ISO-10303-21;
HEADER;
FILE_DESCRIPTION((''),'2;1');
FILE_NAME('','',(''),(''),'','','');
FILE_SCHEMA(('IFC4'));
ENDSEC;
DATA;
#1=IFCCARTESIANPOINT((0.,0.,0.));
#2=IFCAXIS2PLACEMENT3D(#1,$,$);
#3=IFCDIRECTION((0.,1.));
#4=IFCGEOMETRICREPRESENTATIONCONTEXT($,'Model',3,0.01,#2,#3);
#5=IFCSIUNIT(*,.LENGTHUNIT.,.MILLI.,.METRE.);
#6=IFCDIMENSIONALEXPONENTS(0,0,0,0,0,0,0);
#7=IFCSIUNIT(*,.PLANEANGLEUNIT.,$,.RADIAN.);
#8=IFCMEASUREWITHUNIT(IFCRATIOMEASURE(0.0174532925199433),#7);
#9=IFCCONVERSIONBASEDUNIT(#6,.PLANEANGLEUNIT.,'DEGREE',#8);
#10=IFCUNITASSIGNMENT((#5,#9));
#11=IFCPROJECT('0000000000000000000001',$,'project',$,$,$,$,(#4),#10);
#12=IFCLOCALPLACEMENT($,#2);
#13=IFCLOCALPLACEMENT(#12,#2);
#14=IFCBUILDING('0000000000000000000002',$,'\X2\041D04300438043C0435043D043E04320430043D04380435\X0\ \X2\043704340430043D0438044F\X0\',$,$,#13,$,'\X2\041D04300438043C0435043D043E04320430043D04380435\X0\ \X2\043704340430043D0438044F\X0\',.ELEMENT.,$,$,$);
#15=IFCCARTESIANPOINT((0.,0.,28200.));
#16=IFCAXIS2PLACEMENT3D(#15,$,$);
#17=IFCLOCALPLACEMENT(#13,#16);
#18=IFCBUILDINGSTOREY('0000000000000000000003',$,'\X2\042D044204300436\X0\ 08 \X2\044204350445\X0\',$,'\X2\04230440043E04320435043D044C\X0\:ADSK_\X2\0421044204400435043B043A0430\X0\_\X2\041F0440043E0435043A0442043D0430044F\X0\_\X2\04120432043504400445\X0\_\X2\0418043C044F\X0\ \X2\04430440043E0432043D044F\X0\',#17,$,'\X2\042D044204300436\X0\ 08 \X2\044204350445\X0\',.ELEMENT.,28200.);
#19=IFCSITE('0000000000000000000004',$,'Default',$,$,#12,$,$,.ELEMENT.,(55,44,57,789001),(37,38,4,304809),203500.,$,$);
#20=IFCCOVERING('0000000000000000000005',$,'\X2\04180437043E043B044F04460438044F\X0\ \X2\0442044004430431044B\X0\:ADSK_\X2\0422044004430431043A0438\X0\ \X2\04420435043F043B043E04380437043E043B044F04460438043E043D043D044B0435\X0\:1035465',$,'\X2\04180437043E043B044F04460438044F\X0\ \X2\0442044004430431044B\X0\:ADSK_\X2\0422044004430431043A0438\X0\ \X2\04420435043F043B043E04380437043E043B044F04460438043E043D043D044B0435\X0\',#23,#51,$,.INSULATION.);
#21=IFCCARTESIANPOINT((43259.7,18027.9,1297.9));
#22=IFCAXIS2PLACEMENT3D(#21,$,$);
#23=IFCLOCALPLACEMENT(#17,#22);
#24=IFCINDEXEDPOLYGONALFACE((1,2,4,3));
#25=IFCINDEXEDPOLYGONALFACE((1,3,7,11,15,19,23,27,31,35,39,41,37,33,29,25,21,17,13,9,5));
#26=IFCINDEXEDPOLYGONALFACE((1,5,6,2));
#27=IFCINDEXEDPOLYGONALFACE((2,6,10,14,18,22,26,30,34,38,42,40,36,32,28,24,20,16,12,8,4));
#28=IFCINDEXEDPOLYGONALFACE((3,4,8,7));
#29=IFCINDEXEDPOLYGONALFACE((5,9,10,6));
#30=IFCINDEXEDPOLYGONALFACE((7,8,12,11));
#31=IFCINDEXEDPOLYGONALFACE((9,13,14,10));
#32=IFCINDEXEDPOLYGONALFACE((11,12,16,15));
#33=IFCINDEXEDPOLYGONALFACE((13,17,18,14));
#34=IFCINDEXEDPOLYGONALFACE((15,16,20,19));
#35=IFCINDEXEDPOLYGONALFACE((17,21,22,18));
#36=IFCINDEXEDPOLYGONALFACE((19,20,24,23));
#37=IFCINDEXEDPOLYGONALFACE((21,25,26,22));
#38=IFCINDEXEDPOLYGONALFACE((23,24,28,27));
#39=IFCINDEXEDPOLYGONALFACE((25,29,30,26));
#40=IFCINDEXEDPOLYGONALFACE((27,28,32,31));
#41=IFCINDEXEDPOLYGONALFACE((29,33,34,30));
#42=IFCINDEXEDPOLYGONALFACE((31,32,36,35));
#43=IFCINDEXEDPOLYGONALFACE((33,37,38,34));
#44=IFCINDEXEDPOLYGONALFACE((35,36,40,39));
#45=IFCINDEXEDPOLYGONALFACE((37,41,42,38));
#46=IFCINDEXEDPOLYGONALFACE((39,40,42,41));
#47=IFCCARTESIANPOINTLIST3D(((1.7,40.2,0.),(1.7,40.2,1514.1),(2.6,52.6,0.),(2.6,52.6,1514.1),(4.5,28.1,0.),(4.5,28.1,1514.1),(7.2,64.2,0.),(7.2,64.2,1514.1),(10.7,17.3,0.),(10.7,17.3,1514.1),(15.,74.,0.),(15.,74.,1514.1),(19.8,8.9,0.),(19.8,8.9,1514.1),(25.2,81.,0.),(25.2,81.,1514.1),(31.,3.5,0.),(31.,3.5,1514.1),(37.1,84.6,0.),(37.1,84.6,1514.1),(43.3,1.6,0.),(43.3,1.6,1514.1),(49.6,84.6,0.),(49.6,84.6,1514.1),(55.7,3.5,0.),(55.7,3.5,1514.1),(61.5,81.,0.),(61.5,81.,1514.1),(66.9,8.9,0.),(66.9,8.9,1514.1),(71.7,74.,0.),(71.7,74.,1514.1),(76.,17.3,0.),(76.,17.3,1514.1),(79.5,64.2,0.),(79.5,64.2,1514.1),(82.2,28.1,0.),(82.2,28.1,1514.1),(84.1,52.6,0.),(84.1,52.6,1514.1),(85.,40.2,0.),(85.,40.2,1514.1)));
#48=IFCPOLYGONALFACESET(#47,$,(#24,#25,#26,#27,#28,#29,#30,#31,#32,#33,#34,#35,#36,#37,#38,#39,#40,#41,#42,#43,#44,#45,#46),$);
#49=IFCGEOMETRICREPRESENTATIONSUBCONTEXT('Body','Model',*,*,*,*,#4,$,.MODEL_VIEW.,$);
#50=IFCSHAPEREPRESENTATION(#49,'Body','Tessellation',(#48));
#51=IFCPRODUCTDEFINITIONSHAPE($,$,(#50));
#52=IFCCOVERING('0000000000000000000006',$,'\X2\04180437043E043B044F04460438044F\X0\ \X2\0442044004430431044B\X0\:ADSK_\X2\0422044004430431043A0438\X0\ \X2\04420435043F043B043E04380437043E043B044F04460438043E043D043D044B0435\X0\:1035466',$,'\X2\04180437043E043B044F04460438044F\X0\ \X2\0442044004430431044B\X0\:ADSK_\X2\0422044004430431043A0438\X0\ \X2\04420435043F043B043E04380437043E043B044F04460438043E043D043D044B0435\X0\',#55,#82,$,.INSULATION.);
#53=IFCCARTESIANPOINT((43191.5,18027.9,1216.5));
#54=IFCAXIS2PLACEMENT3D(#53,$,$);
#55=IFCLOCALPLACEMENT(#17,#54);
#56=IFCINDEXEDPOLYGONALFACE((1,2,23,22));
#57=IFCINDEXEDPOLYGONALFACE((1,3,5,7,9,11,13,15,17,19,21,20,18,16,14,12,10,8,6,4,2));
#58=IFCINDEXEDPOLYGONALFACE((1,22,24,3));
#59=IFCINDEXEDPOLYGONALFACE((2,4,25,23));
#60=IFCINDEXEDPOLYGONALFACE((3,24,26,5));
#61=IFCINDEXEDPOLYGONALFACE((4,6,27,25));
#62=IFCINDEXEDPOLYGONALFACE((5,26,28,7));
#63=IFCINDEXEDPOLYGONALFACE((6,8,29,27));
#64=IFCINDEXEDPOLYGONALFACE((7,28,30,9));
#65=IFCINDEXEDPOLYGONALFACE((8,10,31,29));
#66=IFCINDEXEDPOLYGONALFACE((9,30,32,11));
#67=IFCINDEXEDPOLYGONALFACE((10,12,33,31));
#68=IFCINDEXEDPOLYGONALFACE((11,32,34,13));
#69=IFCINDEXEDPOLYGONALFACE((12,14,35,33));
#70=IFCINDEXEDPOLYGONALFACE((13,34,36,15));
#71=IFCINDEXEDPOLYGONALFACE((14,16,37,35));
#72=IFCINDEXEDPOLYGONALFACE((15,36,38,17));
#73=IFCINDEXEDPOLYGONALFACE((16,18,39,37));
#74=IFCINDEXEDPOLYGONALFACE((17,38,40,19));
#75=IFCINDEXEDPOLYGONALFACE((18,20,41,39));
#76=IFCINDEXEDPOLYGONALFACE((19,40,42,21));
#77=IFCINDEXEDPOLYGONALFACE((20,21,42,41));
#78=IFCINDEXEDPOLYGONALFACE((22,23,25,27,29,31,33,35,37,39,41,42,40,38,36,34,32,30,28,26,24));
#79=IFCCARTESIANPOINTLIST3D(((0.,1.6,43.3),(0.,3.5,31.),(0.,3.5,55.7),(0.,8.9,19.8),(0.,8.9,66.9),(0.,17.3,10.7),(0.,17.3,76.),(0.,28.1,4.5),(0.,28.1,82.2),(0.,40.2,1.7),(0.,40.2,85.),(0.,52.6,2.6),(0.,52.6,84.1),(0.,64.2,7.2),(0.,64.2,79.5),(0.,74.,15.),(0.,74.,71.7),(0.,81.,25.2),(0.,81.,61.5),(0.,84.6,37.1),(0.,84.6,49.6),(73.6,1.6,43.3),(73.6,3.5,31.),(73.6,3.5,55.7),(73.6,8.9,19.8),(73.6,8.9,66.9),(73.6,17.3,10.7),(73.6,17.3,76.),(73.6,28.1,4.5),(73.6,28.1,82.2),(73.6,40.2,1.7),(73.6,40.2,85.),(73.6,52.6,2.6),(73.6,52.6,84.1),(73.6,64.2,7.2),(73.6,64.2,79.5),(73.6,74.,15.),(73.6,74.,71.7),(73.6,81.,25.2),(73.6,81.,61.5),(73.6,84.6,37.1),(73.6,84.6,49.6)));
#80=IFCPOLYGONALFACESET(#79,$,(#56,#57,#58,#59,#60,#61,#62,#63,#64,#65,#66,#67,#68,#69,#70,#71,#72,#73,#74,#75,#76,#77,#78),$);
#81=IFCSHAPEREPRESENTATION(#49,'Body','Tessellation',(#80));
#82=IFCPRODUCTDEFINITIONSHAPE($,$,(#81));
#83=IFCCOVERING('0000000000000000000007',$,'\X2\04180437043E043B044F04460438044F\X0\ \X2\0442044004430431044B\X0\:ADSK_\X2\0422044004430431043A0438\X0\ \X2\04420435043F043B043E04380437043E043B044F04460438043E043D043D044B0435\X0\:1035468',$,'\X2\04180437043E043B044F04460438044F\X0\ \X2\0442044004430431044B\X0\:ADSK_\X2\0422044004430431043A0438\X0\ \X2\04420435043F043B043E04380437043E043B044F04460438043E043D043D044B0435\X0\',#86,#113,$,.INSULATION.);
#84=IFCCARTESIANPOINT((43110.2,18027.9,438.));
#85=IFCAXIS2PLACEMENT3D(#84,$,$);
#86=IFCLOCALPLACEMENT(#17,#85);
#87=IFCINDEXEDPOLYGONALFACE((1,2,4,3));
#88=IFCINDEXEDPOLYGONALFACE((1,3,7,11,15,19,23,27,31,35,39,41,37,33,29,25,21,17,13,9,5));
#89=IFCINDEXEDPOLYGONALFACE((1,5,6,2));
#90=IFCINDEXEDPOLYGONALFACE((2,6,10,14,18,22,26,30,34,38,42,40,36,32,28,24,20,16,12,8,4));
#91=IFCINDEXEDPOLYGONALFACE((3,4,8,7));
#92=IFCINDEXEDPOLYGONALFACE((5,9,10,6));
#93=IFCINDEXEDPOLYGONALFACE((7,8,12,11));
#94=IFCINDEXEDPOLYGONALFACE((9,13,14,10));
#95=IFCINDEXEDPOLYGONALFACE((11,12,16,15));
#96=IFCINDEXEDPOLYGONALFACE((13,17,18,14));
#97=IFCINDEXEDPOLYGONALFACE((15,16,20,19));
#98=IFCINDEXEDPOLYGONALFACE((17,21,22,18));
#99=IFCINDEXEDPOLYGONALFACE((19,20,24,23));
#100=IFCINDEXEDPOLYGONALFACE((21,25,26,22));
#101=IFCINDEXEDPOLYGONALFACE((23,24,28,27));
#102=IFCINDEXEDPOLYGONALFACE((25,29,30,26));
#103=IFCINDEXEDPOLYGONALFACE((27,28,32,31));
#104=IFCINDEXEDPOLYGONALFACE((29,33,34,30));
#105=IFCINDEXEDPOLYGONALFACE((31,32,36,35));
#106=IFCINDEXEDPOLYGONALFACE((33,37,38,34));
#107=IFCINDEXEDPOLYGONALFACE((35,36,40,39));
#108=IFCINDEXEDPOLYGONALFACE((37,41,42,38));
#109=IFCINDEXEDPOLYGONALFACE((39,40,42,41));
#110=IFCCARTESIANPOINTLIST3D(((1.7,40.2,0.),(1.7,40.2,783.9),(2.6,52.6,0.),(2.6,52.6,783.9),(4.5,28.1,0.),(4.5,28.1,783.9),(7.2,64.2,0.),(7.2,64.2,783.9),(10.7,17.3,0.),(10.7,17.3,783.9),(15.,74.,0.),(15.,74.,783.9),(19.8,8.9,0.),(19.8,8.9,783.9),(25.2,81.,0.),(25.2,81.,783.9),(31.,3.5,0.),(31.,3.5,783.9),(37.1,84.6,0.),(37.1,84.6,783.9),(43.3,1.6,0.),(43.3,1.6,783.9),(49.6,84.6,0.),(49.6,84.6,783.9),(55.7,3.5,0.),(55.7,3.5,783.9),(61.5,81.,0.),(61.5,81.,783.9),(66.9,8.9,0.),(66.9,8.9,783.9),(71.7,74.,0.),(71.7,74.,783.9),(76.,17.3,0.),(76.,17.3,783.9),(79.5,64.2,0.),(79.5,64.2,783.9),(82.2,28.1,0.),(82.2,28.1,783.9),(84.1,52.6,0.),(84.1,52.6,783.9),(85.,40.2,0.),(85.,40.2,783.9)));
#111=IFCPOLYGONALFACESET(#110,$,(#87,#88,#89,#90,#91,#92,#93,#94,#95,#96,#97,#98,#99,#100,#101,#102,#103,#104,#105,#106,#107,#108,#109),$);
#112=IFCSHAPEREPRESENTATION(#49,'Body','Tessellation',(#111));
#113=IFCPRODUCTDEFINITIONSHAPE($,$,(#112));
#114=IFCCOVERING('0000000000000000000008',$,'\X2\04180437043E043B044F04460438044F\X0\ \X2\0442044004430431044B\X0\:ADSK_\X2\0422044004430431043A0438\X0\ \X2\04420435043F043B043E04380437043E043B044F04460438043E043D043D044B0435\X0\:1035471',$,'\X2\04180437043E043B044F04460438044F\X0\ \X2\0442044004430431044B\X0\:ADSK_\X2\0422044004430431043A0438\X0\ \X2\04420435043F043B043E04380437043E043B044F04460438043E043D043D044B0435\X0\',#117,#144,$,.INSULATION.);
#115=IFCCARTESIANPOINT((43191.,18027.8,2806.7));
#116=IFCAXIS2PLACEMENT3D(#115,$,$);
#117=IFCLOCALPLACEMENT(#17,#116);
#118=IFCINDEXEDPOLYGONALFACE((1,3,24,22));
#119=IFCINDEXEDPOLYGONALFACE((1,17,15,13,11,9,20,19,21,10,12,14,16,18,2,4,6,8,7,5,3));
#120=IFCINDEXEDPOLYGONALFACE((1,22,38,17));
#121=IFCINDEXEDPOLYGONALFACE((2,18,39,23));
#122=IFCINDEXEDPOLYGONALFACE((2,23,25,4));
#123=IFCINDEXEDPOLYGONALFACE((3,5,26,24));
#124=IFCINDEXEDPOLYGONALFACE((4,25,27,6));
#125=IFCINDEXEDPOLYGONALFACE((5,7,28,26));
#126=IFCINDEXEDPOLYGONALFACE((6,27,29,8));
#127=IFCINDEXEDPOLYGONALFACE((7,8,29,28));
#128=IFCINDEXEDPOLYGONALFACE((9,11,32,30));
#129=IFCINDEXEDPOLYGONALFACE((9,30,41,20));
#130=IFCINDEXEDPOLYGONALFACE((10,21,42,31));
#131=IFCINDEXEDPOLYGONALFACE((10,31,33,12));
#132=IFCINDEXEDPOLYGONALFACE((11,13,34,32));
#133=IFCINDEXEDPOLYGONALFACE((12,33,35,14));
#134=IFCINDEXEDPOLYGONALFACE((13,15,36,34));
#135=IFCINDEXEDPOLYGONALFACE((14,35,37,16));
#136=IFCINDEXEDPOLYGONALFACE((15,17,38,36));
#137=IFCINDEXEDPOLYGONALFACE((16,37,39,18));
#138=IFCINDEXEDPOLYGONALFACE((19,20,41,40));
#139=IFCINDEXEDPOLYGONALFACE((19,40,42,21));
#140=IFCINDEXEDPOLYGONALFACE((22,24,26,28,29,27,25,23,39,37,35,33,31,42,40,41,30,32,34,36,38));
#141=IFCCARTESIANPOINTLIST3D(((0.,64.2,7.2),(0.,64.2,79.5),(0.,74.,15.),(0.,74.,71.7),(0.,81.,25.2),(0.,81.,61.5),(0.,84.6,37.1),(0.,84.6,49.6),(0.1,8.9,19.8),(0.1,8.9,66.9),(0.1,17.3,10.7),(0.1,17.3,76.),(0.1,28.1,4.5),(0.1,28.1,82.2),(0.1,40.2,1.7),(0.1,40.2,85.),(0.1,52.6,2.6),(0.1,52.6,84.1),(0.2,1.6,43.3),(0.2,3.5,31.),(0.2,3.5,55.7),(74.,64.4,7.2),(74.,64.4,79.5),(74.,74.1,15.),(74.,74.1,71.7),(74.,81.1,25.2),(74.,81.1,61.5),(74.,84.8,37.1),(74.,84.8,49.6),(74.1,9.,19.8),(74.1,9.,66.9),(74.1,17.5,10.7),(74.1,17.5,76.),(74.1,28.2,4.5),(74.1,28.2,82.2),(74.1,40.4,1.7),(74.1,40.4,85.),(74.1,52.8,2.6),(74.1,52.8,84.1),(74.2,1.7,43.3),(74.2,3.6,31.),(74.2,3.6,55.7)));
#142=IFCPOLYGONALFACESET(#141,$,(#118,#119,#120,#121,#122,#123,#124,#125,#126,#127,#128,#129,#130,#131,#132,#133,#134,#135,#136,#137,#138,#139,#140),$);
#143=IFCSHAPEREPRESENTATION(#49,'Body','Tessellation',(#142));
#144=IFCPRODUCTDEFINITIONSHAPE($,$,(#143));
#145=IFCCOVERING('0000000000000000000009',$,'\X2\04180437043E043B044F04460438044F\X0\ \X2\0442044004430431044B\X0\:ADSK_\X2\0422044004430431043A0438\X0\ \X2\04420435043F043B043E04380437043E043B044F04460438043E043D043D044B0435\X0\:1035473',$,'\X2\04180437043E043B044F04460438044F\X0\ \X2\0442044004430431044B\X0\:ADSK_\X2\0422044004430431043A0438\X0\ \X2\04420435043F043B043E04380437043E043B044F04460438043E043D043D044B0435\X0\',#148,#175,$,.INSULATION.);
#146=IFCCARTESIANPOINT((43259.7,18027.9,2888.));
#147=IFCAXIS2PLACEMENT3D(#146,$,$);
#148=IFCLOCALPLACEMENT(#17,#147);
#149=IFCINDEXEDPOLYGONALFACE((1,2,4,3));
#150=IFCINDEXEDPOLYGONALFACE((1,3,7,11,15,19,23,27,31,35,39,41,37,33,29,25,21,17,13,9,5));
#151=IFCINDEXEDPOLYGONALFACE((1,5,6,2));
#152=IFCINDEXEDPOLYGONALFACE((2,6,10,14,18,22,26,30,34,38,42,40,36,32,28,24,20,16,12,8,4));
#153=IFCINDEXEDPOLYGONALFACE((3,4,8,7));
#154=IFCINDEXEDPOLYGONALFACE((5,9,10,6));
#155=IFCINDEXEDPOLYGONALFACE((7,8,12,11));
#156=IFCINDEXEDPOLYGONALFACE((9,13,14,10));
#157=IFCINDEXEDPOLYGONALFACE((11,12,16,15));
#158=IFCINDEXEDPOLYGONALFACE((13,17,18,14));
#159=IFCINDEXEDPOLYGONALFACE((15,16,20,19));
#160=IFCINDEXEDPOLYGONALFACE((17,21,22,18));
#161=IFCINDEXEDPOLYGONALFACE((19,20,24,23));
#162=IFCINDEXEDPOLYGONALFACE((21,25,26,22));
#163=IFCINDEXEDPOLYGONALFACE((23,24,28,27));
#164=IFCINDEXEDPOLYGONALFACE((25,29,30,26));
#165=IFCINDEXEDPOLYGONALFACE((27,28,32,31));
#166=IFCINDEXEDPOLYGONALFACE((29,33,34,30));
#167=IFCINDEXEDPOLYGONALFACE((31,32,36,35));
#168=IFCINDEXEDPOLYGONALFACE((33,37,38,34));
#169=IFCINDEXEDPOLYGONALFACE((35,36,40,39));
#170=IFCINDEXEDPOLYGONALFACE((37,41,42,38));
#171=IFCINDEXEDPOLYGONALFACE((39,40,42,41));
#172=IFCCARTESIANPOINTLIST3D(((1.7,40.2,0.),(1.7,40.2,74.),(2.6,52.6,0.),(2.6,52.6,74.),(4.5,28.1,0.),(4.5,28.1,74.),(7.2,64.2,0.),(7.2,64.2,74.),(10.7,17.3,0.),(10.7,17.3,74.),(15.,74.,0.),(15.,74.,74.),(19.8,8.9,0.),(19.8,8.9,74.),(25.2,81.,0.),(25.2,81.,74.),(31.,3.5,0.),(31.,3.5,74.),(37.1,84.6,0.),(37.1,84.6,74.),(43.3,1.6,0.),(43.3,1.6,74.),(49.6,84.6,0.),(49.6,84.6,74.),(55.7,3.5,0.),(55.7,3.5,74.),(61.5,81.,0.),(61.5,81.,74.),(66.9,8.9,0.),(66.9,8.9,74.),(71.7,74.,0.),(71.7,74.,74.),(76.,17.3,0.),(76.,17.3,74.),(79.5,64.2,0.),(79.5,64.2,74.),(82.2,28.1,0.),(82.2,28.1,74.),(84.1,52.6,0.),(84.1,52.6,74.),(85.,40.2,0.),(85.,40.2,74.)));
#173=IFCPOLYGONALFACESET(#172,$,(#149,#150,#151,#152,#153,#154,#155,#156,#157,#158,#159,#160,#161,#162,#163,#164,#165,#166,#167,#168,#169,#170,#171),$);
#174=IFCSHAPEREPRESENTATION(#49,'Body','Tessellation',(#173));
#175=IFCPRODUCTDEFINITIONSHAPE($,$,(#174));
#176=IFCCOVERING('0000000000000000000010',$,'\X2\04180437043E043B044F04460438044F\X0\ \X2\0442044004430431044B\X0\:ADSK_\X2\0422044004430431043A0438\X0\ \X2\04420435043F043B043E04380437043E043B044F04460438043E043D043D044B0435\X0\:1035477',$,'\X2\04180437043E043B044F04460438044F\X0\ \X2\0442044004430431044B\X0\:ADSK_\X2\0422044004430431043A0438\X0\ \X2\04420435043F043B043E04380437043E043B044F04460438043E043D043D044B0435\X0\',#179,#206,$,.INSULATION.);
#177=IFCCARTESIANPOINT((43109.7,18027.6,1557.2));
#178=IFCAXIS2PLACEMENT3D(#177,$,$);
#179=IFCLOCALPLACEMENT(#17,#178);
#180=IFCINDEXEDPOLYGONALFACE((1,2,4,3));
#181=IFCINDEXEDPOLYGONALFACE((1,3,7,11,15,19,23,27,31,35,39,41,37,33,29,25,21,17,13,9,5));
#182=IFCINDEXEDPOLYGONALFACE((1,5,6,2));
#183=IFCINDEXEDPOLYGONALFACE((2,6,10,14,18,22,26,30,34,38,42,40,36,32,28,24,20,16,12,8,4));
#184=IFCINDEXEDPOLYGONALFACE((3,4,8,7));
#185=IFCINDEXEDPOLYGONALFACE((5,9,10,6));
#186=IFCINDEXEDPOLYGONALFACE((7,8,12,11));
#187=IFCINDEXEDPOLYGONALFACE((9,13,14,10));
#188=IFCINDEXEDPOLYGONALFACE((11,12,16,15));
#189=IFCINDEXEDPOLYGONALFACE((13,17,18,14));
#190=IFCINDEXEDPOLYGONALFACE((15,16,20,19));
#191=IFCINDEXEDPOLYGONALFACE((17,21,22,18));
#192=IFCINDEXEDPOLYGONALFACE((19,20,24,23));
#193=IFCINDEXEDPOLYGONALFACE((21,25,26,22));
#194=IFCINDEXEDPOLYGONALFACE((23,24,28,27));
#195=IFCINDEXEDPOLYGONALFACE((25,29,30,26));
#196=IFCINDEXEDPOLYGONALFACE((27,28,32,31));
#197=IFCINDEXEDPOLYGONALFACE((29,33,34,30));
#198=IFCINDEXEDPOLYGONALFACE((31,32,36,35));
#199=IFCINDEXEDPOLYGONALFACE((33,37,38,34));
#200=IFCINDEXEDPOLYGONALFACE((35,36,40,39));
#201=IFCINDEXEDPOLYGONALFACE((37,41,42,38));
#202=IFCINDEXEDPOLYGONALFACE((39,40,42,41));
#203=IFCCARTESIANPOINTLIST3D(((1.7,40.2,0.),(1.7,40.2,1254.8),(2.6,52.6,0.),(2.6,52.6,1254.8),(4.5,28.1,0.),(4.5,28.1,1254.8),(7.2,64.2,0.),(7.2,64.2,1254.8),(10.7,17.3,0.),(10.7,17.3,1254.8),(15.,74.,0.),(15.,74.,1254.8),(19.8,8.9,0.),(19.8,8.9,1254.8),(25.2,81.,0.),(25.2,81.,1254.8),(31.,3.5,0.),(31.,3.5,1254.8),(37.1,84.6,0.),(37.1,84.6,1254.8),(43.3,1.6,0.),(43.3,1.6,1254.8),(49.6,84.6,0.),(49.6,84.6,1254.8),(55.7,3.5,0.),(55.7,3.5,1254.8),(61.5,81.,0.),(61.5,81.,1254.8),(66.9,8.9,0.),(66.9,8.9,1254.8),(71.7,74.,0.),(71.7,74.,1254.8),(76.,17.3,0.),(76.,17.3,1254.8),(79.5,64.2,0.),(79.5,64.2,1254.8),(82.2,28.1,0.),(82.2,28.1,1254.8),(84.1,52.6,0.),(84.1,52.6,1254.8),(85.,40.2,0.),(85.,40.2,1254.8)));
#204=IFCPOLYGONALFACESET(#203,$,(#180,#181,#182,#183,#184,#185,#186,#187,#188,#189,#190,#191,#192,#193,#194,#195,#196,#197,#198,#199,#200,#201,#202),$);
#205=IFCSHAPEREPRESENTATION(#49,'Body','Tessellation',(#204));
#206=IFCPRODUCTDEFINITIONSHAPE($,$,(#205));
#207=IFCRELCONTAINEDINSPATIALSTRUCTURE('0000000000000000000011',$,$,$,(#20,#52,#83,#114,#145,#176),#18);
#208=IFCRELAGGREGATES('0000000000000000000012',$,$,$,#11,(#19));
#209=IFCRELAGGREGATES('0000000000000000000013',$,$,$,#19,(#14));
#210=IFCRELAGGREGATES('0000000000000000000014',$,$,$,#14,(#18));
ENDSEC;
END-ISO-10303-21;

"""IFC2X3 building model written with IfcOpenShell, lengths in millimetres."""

from ifc_helpers import new_model, entity, si_unit, converted_unit, direction, frame, origin, origin_2d_with_axis, place, context, subcontext, project, spatial, circle, extrude, element, save


model = new_model("IFC2X3")

# Units and contexts
model_context = context("Model", 3, precision=0.01, world=origin(), true_north=direction((0.0, 1.0)))
body_context = subcontext(model_context, "Body", "Model", "MODEL_VIEW")
ifc_project = project(units=[si_unit("LENGTHUNIT", "METRE", prefix="MILLI"), converted_unit("PLANEANGLEUNIT", "DEGREE", entity("IfcRatioMeasure", 0.0174532925199433), si_unit("PLANEANGLEUNIT", "RADIAN"), dimensions=[0, 0, 0, 0, 0, 0, 0])], contexts=[model_context])

# Site, building, storey
site_placement = place(None, origin())
site = spatial("IfcSite", under=ifc_project, at=site_placement, Name="Default", CompositionType="ELEMENT", RefLatitude=(55, 44, 57, 789001), RefLongitude=(37, 38, 4, 304809), RefElevation=203500.0)
building_placement = place(site_placement, origin())
building = spatial("IfcBuilding", under=site, at=building_placement, Name="Наименование здания", LongName="Наименование здания", CompositionType="ELEMENT")
storey_placement = place(building_placement, frame((0.0, 0.0, 28200.0)))
storey = spatial("IfcBuildingStorey", under=building, at=storey_placement, Name="Этаж 08 тех", ObjectType="Уровень:ADSK_Стрелка_Проектная_Вверх_Имя уровня", LongName="Этаж 08 тех", CompositionType="ELEMENT", Elevation=28200.0)

# Coverings
covering_1_placement = place(storey_placement, frame((43259.7, 18027.9, 1297.9)))
element("IfcCovering", 1, at=covering_1_placement, inside=storey, Name="Изоляция трубы:ADSK_Трубки теплоизоляционные:1035465", ObjectType="Изоляция трубы:ADSK_Трубки теплоизоляционные", PredefinedType="INSULATION", context=body_context, shape_type="SweptSolid", body=[
    extrude(circle(Radius=41.8, at=origin_2d_with_axis()), frame((43.4, 43.4, 0.0), z_axis=(0.0, 0.0, 1.0), x_axis=(0.0, -1.0, 0.0)), (0.0, 0.0, 1.0), 1514.1),
])
covering_2_placement = place(storey_placement, frame((43191.5, 18027.9, 1216.5)))
element("IfcCovering", 2, at=covering_2_placement, inside=storey, Name="Изоляция трубы:ADSK_Трубки теплоизоляционные:1035466", ObjectType="Изоляция трубы:ADSK_Трубки теплоизоляционные", PredefinedType="INSULATION", context=body_context, shape_type="SweptSolid", body=[
    extrude(circle(Radius=41.8, at=origin_2d_with_axis()), frame((0.0, 43.4, 43.4), z_axis=(1.0, 0.0, 0.0), x_axis=(0.0, -1.0, 0.0)), (0.0, 0.0, 1.0), 73.6),
])
covering_3_placement = place(storey_placement, frame((43110.2, 18027.9, 438.0)))
element("IfcCovering", 3, at=covering_3_placement, inside=storey, Name="Изоляция трубы:ADSK_Трубки теплоизоляционные:1035468", ObjectType="Изоляция трубы:ADSK_Трубки теплоизоляционные", PredefinedType="INSULATION", context=body_context, shape_type="SweptSolid", body=[
    extrude(circle(Radius=41.8, at=origin_2d_with_axis()), frame((43.4, 43.4, 0.0), z_axis=(0.0, 0.0, 1.0), x_axis=(0.0, -1.0, 0.0)), (0.0, 0.0, 1.0), 783.9),
])
covering_4_placement = place(storey_placement, frame((43191.0, 18027.8, 2806.7)))
element("IfcCovering", 4, at=covering_4_placement, inside=storey, Name="Изоляция трубы:ADSK_Трубки теплоизоляционные:1035471", ObjectType="Изоляция трубы:ADSK_Трубки теплоизоляционные", PredefinedType="INSULATION", context=body_context, shape_type="SweptSolid", body=[
    extrude(circle(Radius=41.8, at=origin_2d_with_axis()), frame((0.1, 43.4, 43.4), z_axis=(0.999998, 0.001963, 0.0), x_axis=(0.001963, -0.999998, 0.0)), (0.0, 0.0, 1.0), 74.0),
])
covering_5_placement = place(storey_placement, frame((43259.7, 18027.9, 2888.0)))
element("IfcCovering", 5, at=covering_5_placement, inside=storey, Name="Изоляция трубы:ADSK_Трубки теплоизоляционные:1035473", ObjectType="Изоляция трубы:ADSK_Трубки теплоизоляционные", PredefinedType="INSULATION", context=body_context, shape_type="SweptSolid", body=[
    extrude(circle(Radius=41.8, at=origin_2d_with_axis()), frame((43.4, 43.4, 0.0), z_axis=(0.0, 0.0, 1.0), x_axis=(0.0, -1.0, 0.0)), (0.0, 0.0, 1.0), 74.0),
])
covering_6_placement = place(storey_placement, frame((43109.7, 18027.6, 1557.2)))
element("IfcCovering", 6, at=covering_6_placement, inside=storey, Name="Изоляция трубы:ADSK_Трубки теплоизоляционные:1035477", ObjectType="Изоляция трубы:ADSK_Трубки теплоизоляционные", PredefinedType="INSULATION", context=body_context, shape_type="SweptSolid", body=[
    extrude(circle(Radius=41.8, at=origin_2d_with_axis()), frame((43.4, 43.4, 0.0), z_axis=(0.0, 0.0, 1.0), x_axis=(0.0, -1.0, 0.0)), (0.0, 0.0, 1.0), 1254.8),
])

save(model, "model.ifc")
